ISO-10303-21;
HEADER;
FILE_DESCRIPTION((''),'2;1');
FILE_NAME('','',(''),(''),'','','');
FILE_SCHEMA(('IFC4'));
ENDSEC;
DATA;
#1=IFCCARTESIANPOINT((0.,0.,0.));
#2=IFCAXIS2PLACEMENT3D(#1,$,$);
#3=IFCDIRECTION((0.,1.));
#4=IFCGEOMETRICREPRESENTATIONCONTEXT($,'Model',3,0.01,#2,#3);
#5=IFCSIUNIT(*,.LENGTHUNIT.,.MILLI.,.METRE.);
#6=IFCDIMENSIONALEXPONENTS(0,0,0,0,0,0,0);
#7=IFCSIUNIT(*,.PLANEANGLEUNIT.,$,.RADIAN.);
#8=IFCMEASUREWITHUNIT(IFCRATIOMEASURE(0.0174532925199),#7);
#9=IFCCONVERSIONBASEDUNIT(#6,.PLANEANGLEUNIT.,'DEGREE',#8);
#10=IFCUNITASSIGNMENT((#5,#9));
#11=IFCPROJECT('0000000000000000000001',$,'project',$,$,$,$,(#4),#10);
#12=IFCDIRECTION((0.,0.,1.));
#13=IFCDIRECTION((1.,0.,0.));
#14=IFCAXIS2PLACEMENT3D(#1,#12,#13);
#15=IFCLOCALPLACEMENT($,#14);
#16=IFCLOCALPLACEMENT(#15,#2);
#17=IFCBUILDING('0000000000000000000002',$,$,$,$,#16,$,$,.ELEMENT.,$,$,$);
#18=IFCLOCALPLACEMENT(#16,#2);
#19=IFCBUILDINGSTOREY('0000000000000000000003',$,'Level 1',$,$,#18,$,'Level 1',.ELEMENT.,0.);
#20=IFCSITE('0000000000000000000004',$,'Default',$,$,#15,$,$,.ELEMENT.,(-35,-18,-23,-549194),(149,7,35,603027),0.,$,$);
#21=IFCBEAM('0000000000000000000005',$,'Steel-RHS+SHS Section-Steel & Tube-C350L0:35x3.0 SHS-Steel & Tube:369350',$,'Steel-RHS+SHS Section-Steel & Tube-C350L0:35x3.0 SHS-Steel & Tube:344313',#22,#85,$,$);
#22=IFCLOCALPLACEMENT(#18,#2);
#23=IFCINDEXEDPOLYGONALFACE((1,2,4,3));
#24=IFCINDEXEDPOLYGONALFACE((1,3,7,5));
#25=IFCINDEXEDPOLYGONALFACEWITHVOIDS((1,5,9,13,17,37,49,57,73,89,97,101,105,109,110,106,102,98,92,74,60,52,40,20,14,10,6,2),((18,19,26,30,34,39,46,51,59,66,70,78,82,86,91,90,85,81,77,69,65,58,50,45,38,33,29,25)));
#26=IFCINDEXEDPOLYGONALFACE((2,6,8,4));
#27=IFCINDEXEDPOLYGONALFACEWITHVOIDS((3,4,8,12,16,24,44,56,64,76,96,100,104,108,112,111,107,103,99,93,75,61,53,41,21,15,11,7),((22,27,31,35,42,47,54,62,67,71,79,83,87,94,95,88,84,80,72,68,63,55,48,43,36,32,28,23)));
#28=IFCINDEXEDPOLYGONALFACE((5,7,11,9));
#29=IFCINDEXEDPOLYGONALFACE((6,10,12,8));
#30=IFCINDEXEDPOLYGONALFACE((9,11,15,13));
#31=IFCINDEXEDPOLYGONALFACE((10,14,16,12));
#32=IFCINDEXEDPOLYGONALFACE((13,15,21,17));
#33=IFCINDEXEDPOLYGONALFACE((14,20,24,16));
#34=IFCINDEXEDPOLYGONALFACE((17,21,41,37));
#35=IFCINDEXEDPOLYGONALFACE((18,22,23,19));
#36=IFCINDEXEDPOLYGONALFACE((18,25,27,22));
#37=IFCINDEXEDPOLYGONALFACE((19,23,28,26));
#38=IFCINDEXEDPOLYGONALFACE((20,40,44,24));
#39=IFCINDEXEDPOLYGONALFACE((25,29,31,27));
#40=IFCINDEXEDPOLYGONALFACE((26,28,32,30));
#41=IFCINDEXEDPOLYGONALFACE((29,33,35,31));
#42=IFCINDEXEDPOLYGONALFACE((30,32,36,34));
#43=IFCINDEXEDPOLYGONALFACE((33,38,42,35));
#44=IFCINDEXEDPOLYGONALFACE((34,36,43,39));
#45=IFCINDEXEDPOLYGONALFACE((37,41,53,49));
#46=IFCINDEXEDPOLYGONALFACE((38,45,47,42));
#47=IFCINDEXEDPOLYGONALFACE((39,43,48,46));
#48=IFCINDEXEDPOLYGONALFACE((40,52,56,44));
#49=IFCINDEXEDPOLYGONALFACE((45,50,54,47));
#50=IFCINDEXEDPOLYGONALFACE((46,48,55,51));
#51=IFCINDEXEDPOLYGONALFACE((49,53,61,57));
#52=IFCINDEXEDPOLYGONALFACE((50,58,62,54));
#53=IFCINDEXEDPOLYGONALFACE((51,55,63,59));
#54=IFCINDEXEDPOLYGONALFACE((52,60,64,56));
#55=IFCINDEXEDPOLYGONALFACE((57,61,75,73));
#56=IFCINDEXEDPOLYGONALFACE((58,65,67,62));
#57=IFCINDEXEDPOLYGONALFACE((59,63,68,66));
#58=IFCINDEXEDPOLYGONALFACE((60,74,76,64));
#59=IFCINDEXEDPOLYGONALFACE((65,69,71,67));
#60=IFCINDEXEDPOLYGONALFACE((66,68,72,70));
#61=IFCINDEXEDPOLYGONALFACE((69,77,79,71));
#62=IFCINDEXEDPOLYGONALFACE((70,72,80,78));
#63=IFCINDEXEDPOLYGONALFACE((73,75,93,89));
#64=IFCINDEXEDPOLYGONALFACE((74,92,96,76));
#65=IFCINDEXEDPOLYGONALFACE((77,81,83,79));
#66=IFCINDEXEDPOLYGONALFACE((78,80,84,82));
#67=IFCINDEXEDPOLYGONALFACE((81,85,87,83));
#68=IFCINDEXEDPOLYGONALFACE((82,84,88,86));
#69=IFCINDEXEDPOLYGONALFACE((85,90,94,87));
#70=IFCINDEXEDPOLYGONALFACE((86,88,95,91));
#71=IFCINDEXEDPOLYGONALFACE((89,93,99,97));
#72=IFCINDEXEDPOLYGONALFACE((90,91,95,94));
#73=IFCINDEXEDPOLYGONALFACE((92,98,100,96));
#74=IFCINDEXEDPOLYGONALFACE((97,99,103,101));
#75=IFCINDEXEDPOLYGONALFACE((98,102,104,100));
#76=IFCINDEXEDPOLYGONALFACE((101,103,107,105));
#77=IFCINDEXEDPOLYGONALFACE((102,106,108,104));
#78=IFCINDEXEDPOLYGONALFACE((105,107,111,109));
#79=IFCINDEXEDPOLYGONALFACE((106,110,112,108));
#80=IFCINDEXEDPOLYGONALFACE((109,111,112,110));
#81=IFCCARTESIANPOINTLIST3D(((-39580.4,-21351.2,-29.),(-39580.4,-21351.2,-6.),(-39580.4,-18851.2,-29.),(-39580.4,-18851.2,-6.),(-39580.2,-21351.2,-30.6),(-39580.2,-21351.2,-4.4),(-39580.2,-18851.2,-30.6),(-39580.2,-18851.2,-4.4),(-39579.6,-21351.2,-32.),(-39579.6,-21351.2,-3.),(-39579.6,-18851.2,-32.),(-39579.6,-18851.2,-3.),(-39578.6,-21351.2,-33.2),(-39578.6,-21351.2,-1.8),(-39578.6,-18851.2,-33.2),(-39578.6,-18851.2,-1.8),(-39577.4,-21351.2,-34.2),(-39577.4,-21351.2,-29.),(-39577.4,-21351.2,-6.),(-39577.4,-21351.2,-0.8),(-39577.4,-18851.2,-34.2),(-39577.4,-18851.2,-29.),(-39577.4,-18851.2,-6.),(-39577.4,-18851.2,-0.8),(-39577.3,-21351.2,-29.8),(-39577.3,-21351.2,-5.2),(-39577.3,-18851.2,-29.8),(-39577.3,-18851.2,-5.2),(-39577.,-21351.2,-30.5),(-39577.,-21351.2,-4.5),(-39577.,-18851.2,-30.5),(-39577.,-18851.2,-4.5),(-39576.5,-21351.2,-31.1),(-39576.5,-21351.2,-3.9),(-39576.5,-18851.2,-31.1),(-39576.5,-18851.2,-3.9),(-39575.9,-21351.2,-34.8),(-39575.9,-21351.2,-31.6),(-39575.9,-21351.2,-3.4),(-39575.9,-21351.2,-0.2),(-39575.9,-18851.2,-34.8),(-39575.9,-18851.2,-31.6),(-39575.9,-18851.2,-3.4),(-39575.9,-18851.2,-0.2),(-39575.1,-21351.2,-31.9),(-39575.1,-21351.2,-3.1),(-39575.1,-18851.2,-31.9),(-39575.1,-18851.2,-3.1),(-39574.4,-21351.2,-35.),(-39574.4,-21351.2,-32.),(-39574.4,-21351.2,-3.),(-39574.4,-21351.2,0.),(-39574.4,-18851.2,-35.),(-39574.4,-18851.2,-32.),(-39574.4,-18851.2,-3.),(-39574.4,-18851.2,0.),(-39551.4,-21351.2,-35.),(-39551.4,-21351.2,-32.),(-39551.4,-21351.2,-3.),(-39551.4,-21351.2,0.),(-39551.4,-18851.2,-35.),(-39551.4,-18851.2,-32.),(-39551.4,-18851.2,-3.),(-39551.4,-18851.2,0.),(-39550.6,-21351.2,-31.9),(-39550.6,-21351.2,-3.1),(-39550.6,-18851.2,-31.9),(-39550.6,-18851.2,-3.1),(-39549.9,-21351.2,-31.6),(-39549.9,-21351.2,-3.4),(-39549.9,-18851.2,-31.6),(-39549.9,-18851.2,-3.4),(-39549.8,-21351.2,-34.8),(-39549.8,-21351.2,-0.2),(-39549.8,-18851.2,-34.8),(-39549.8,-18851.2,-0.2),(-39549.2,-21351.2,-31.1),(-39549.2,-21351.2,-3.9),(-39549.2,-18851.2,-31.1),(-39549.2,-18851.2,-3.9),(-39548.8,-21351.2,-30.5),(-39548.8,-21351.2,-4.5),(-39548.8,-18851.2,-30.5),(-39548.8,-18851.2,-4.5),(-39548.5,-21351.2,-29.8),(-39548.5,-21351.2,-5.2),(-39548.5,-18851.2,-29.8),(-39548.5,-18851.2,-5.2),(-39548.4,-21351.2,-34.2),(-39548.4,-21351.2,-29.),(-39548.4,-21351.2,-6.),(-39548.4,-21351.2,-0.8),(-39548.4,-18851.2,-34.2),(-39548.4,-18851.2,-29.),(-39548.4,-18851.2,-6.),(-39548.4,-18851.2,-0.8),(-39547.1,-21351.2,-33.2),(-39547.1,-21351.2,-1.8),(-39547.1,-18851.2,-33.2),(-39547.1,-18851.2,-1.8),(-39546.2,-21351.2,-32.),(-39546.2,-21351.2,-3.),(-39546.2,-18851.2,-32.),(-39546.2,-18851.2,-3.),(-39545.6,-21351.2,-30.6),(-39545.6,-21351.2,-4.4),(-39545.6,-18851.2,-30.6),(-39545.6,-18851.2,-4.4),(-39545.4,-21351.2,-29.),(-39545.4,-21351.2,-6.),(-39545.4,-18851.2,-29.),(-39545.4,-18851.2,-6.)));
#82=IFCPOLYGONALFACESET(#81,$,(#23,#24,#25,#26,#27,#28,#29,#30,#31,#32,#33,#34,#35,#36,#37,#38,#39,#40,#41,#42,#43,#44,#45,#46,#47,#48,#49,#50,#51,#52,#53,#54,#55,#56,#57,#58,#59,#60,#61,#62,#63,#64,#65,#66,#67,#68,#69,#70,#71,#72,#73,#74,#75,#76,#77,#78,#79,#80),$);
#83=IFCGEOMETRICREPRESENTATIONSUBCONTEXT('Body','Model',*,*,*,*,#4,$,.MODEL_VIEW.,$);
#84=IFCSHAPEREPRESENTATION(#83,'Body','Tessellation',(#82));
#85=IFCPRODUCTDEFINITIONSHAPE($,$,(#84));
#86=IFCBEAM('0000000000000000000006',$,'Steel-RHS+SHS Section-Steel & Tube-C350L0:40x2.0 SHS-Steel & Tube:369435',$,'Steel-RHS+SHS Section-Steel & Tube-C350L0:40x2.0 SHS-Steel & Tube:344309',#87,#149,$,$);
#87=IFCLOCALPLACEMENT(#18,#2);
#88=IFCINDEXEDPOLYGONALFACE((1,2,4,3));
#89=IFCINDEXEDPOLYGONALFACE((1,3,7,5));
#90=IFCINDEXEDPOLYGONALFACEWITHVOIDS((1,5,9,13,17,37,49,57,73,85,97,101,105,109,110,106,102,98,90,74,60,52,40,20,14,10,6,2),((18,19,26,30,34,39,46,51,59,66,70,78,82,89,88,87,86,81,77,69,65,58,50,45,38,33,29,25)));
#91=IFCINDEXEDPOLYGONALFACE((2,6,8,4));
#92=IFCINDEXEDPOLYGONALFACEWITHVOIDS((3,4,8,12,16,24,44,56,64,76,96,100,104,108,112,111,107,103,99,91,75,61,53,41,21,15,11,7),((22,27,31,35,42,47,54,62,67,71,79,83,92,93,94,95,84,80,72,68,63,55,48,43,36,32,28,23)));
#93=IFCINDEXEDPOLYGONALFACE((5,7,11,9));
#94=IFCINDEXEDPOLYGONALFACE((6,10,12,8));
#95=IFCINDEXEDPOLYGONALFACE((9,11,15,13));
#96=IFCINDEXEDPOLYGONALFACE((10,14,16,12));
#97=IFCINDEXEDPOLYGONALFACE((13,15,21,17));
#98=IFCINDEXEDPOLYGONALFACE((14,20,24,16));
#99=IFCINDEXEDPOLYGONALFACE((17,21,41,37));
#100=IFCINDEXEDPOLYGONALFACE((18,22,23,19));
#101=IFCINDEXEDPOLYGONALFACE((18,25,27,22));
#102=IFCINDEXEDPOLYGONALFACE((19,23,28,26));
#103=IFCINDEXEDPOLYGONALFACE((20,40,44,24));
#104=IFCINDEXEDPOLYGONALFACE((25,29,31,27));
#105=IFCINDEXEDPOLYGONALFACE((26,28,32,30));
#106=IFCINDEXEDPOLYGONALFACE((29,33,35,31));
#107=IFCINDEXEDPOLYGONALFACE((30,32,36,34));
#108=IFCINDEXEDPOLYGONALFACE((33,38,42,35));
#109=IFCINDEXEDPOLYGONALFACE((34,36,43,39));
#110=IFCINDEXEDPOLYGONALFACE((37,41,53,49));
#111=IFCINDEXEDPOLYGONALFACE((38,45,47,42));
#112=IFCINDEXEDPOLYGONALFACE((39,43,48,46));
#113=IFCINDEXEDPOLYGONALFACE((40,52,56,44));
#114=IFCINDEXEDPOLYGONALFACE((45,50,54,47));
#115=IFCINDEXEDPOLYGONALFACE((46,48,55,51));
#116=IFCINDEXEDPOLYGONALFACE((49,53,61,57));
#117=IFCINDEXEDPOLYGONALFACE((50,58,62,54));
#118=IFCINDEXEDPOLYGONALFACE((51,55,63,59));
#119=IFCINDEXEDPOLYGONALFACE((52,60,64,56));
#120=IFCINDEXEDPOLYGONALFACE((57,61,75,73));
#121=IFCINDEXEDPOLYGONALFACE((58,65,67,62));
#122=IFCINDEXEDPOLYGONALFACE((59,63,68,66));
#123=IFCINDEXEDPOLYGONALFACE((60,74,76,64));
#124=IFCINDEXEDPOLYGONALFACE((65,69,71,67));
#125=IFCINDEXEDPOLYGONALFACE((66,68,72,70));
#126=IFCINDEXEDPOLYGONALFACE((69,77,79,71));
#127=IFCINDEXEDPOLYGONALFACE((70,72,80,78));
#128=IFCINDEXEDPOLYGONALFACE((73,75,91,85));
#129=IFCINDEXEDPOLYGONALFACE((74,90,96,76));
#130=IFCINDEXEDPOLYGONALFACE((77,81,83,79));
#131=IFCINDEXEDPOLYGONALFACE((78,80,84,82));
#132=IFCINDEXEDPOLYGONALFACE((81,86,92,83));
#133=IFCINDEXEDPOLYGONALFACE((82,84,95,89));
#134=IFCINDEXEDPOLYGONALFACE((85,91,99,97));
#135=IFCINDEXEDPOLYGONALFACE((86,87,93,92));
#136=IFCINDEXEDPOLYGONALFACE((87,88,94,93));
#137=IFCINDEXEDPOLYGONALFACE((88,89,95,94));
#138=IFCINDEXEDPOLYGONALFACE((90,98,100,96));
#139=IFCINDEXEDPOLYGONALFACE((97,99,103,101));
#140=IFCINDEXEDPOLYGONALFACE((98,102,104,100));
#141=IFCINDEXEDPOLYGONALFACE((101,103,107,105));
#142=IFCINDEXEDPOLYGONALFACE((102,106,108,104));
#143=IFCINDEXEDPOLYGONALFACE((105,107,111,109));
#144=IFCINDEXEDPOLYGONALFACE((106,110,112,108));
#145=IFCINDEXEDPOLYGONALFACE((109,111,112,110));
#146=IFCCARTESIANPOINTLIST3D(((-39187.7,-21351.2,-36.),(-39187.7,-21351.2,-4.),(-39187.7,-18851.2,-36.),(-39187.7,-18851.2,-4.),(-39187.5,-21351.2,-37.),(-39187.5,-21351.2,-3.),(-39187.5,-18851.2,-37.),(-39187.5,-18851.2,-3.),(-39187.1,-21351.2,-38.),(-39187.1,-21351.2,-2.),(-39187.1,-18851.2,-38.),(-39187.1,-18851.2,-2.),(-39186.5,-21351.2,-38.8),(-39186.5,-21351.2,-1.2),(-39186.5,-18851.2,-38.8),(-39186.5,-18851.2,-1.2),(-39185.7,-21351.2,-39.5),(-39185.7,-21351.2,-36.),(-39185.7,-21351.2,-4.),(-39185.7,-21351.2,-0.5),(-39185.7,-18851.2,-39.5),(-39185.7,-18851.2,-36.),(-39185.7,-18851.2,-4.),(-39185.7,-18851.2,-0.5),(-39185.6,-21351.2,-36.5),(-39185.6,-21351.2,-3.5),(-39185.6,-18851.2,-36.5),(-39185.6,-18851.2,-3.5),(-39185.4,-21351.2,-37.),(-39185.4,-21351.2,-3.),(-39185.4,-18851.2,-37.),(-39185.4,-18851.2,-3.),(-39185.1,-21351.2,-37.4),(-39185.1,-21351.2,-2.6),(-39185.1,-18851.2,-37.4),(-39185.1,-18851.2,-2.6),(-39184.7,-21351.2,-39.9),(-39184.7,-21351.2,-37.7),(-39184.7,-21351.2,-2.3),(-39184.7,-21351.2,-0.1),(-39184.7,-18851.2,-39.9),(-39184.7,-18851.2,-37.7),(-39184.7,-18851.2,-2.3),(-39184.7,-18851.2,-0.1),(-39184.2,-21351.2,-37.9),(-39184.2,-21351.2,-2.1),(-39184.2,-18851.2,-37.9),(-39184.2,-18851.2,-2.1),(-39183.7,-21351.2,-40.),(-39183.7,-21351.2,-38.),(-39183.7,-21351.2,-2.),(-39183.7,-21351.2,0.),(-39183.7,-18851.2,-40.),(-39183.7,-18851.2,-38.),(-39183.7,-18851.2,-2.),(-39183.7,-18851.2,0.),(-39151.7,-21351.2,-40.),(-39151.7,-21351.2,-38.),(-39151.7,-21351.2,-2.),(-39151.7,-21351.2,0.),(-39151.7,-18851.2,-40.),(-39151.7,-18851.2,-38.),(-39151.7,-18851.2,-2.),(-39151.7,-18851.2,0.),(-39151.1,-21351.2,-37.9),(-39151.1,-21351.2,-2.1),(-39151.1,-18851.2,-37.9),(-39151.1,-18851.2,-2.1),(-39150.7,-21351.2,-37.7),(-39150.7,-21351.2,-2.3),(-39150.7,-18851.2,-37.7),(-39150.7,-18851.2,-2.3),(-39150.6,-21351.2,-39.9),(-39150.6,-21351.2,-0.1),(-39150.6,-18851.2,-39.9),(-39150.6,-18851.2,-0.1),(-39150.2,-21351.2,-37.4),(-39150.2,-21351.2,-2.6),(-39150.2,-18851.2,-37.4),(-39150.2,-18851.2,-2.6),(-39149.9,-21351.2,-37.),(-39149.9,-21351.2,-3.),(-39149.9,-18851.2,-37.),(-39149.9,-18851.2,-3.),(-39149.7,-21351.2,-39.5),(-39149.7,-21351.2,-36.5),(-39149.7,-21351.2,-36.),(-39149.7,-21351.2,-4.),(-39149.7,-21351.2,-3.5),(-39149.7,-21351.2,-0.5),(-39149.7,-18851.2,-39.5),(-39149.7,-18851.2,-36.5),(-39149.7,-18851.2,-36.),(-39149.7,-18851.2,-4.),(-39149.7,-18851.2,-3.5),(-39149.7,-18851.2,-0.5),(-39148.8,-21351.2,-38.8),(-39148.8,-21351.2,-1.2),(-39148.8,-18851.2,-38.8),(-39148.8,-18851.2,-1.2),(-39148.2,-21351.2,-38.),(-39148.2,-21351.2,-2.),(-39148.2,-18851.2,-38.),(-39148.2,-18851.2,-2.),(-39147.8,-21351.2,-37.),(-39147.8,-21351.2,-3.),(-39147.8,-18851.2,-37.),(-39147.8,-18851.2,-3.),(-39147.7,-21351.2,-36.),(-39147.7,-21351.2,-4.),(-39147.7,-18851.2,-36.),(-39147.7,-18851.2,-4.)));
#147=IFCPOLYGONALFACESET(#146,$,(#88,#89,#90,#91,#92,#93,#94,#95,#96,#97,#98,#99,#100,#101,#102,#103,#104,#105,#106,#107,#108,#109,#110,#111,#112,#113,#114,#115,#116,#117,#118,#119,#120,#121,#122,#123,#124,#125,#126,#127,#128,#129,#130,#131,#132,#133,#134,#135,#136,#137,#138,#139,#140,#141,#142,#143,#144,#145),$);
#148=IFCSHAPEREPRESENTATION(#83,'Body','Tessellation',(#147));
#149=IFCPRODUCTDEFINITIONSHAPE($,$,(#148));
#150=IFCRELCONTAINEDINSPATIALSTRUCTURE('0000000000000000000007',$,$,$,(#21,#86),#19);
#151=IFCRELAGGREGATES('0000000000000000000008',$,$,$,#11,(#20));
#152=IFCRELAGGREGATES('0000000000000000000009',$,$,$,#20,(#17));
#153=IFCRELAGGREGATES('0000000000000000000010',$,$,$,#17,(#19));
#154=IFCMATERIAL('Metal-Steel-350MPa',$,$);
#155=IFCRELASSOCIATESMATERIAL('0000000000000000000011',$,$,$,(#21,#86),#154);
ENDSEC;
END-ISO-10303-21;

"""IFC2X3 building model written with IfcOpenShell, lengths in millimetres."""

from ifc_helpers import new_model, entity, si_unit, converted_unit, direction, frame, frame_2d, origin, origin_with_axes, place, context, subcontext, project, spatial, polyline, circle_curve, parameter, trimmed, segment, composite_curve, outline, extrude, material, element, save


model = new_model("IFC2X3")

# Units and contexts
model_context = context("Model", 3, precision=0.01, world=origin(), true_north=direction((0.0, 1.0)))
body_context = subcontext(model_context, "Body", "Model", "MODEL_VIEW")
ifc_project = project(units=[si_unit("LENGTHUNIT", "METRE", prefix="MILLI"), converted_unit("PLANEANGLEUNIT", "DEGREE", entity("IfcRatioMeasure", 0.0174532925199), si_unit("PLANEANGLEUNIT", "RADIAN"), dimensions=[0, 0, 0, 0, 0, 0, 0])], contexts=[model_context])

# Site, building, storey
site_placement = place(None, origin_with_axes())
site = spatial("IfcSite", under=ifc_project, at=site_placement, Name="Default", CompositionType="ELEMENT", RefLatitude=(-35, -18, -23, -549194), RefLongitude=(149, 7, 35, 603027), RefElevation=0.0)
building_placement = place(site_placement, origin())
building = spatial("IfcBuilding", under=site, at=building_placement, CompositionType="ELEMENT")
storey_placement = place(building_placement, origin())
storey = spatial("IfcBuildingStorey", under=building, at=storey_placement, Name="Level 1", LongName="Level 1", CompositionType="ELEMENT", Elevation=0.0)

# Beams
ifc_material = material(Name="Metal-Steel-350MPa")
beam_1_placement = place(storey_placement, frame((-39562.9, -18851.2, 0.0), z_axis=(0.0, 0.0, 1.0), x_axis=(0.0, -1.0, 0.0)))
element("IfcBeam", 1, at=beam_1_placement, inside=storey, material=ifc_material, Name="Steel-RHS+SHS Section-Steel & Tube-C350L0:35x3.0 SHS-Steel & Tube:369350", ObjectType="Steel-RHS+SHS Section-Steel & Tube-C350L0:35x3.0 SHS-Steel & Tube:344313", context=body_context, shape_type="SweptSolid", body=[
    extrude(outline(composite_curve([segment(trimmed(circle_curve(frame_2d((-11.5, -11.5), x_axis=(1.0, 0.0)), 6.0), [parameter(180.0)], [parameter(270.0)], True, "PARAMETER"), True, "CONTINUOUS"), segment(polyline([(-11.5, -17.5), (11.5, -17.5)]), True, "CONTINUOUS"), segment(trimmed(circle_curve(frame_2d((11.5, -11.5), x_axis=(1.0, 0.0)), 6.0), [parameter(270.0)], [parameter(0.0)], True, "PARAMETER"), True, "CONTINUOUS"), segment(polyline([(17.5, -11.5), (17.5, 11.5)]), True, "CONTINUOUS"), segment(trimmed(circle_curve(frame_2d((11.5, 11.5), x_axis=(1.0, 0.0)), 6.0), [parameter(0.0)], [parameter(90.0)], True, "PARAMETER"), True, "CONTINUOUS"), segment(polyline([(11.5, 17.5), (-11.5, 17.5)]), True, "CONTINUOUS"), segment(trimmed(circle_curve(frame_2d((-11.5, 11.5), x_axis=(1.0, 0.0)), 6.0), [parameter(90.0)], [parameter(180.0)], True, "PARAMETER"), True, "CONTINUOUS"), segment(polyline([(-17.5, 11.5), (-17.5, -11.5)]), True, "CONTINUOUS")], self_intersect=False), holes=[composite_curve([segment(polyline([(11.5, -14.5), (-11.5, -14.5)]), True, "CONTINUOUS"), segment(trimmed(circle_curve(frame_2d((-11.5, -11.5), x_axis=(1.0, 0.0)), 3.0), [parameter(180.0)], [parameter(270.0)], True, "PARAMETER"), False, "CONTINUOUS"), segment(polyline([(-14.5, -11.5), (-14.5, 11.5)]), True, "CONTINUOUS"), segment(trimmed(circle_curve(frame_2d((-11.5, 11.5), x_axis=(1.0, 0.0)), 3.0), [parameter(90.0)], [parameter(180.0)], True, "PARAMETER"), False, "CONTINUOUS"), segment(polyline([(-11.5, 14.5), (11.5, 14.5)]), True, "CONTINUOUS"), segment(trimmed(circle_curve(frame_2d((11.5, 11.5), x_axis=(1.0, 0.0)), 3.0), [parameter(360.0)], [parameter(90.0)], True, "PARAMETER"), False, "CONTINUOUS"), segment(polyline([(14.5, 11.5), (14.5, -11.5)]), True, "CONTINUOUS"), segment(trimmed(circle_curve(frame_2d((11.5, -11.5), x_axis=(1.0, 0.0)), 3.0), [parameter(270.0)], [parameter(360.0)], True, "PARAMETER"), False, "CONTINUOUS")], self_intersect=False)]), frame((0.0, 0.0, -17.5), z_axis=(1.0, 0.0, 0.0), x_axis=(0.0, -1.0, 0.0)), (0.0, 0.0, 1.0), 2500.0),
])
beam_2_placement = place(storey_placement, frame((-39167.7, -18851.2, 0.0), z_axis=(0.0, 0.0, 1.0), x_axis=(0.0, -1.0, 0.0)))
element("IfcBeam", 2, at=beam_2_placement, inside=storey, material=ifc_material, Name="Steel-RHS+SHS Section-Steel & Tube-C350L0:40x2.0 SHS-Steel & Tube:369435", ObjectType="Steel-RHS+SHS Section-Steel & Tube-C350L0:40x2.0 SHS-Steel & Tube:344309", context=body_context, shape_type="SweptSolid", body=[
    extrude(outline(composite_curve([segment(trimmed(circle_curve(frame_2d((-16.0, -16.0), x_axis=(1.0, 0.0)), 4.0), [parameter(180.0)], [parameter(270.0)], True, "PARAMETER"), True, "CONTINUOUS"), segment(polyline([(-16.0, -20.0), (16.0, -20.0)]), True, "CONTINUOUS"), segment(trimmed(circle_curve(frame_2d((16.0, -16.0), x_axis=(1.0, 0.0)), 4.0), [parameter(270.0)], [parameter(0.0)], True, "PARAMETER"), True, "CONTINUOUS"), segment(polyline([(20.0, -16.0), (20.0, 16.0)]), True, "CONTINUOUS"), segment(trimmed(circle_curve(frame_2d((16.0, 16.0), x_axis=(1.0, 0.0)), 4.0), [parameter(0.0)], [parameter(90.0)], True, "PARAMETER"), True, "CONTINUOUS"), segment(polyline([(16.0, 20.0), (-16.0, 20.0)]), True, "CONTINUOUS"), segment(trimmed(circle_curve(frame_2d((-16.0, 16.0), x_axis=(1.0, 0.0)), 4.0), [parameter(90.0)], [parameter(180.0)], True, "PARAMETER"), True, "CONTINUOUS"), segment(polyline([(-20.0, 16.0), (-20.0, -16.0)]), True, "CONTINUOUS")], self_intersect=False), holes=[composite_curve([segment(polyline([(16.0, -18.0), (-16.0, -18.0)]), True, "CONTINUOUS"), segment(trimmed(circle_curve(frame_2d((-16.0, -16.0), x_axis=(1.0, 0.0)), 2.0), [parameter(180.0)], [parameter(270.0)], True, "PARAMETER"), False, "CONTINUOUS"), segment(polyline([(-18.0, -16.0), (-18.0, 16.0)]), True, "CONTINUOUS"), segment(trimmed(circle_curve(frame_2d((-16.0, 16.0), x_axis=(1.0, 0.0)), 2.0), [parameter(90.0)], [parameter(180.0)], True, "PARAMETER"), False, "CONTINUOUS"), segment(polyline([(-16.0, 18.0), (16.0, 18.0)]), True, "CONTINUOUS"), segment(trimmed(circle_curve(frame_2d((16.0, 16.0), x_axis=(1.0, 0.0)), 2.0), [parameter(360.0)], [parameter(90.0)], True, "PARAMETER"), False, "CONTINUOUS"), segment(polyline([(18.0, 16.0), (18.0, -16.0)]), True, "CONTINUOUS"), segment(trimmed(circle_curve(frame_2d((16.0, -16.0), x_axis=(1.0, 0.0)), 2.0), [parameter(270.0)], [parameter(0.0)], True, "PARAMETER"), False, "CONTINUOUS")], self_intersect=False)]), frame((0.0, 0.0, -20.0), z_axis=(1.0, 0.0, 0.0), x_axis=(0.0, -1.0, 0.0)), (0.0, 0.0, 1.0), 2500.0),
])

save(model, "model.ifc")
